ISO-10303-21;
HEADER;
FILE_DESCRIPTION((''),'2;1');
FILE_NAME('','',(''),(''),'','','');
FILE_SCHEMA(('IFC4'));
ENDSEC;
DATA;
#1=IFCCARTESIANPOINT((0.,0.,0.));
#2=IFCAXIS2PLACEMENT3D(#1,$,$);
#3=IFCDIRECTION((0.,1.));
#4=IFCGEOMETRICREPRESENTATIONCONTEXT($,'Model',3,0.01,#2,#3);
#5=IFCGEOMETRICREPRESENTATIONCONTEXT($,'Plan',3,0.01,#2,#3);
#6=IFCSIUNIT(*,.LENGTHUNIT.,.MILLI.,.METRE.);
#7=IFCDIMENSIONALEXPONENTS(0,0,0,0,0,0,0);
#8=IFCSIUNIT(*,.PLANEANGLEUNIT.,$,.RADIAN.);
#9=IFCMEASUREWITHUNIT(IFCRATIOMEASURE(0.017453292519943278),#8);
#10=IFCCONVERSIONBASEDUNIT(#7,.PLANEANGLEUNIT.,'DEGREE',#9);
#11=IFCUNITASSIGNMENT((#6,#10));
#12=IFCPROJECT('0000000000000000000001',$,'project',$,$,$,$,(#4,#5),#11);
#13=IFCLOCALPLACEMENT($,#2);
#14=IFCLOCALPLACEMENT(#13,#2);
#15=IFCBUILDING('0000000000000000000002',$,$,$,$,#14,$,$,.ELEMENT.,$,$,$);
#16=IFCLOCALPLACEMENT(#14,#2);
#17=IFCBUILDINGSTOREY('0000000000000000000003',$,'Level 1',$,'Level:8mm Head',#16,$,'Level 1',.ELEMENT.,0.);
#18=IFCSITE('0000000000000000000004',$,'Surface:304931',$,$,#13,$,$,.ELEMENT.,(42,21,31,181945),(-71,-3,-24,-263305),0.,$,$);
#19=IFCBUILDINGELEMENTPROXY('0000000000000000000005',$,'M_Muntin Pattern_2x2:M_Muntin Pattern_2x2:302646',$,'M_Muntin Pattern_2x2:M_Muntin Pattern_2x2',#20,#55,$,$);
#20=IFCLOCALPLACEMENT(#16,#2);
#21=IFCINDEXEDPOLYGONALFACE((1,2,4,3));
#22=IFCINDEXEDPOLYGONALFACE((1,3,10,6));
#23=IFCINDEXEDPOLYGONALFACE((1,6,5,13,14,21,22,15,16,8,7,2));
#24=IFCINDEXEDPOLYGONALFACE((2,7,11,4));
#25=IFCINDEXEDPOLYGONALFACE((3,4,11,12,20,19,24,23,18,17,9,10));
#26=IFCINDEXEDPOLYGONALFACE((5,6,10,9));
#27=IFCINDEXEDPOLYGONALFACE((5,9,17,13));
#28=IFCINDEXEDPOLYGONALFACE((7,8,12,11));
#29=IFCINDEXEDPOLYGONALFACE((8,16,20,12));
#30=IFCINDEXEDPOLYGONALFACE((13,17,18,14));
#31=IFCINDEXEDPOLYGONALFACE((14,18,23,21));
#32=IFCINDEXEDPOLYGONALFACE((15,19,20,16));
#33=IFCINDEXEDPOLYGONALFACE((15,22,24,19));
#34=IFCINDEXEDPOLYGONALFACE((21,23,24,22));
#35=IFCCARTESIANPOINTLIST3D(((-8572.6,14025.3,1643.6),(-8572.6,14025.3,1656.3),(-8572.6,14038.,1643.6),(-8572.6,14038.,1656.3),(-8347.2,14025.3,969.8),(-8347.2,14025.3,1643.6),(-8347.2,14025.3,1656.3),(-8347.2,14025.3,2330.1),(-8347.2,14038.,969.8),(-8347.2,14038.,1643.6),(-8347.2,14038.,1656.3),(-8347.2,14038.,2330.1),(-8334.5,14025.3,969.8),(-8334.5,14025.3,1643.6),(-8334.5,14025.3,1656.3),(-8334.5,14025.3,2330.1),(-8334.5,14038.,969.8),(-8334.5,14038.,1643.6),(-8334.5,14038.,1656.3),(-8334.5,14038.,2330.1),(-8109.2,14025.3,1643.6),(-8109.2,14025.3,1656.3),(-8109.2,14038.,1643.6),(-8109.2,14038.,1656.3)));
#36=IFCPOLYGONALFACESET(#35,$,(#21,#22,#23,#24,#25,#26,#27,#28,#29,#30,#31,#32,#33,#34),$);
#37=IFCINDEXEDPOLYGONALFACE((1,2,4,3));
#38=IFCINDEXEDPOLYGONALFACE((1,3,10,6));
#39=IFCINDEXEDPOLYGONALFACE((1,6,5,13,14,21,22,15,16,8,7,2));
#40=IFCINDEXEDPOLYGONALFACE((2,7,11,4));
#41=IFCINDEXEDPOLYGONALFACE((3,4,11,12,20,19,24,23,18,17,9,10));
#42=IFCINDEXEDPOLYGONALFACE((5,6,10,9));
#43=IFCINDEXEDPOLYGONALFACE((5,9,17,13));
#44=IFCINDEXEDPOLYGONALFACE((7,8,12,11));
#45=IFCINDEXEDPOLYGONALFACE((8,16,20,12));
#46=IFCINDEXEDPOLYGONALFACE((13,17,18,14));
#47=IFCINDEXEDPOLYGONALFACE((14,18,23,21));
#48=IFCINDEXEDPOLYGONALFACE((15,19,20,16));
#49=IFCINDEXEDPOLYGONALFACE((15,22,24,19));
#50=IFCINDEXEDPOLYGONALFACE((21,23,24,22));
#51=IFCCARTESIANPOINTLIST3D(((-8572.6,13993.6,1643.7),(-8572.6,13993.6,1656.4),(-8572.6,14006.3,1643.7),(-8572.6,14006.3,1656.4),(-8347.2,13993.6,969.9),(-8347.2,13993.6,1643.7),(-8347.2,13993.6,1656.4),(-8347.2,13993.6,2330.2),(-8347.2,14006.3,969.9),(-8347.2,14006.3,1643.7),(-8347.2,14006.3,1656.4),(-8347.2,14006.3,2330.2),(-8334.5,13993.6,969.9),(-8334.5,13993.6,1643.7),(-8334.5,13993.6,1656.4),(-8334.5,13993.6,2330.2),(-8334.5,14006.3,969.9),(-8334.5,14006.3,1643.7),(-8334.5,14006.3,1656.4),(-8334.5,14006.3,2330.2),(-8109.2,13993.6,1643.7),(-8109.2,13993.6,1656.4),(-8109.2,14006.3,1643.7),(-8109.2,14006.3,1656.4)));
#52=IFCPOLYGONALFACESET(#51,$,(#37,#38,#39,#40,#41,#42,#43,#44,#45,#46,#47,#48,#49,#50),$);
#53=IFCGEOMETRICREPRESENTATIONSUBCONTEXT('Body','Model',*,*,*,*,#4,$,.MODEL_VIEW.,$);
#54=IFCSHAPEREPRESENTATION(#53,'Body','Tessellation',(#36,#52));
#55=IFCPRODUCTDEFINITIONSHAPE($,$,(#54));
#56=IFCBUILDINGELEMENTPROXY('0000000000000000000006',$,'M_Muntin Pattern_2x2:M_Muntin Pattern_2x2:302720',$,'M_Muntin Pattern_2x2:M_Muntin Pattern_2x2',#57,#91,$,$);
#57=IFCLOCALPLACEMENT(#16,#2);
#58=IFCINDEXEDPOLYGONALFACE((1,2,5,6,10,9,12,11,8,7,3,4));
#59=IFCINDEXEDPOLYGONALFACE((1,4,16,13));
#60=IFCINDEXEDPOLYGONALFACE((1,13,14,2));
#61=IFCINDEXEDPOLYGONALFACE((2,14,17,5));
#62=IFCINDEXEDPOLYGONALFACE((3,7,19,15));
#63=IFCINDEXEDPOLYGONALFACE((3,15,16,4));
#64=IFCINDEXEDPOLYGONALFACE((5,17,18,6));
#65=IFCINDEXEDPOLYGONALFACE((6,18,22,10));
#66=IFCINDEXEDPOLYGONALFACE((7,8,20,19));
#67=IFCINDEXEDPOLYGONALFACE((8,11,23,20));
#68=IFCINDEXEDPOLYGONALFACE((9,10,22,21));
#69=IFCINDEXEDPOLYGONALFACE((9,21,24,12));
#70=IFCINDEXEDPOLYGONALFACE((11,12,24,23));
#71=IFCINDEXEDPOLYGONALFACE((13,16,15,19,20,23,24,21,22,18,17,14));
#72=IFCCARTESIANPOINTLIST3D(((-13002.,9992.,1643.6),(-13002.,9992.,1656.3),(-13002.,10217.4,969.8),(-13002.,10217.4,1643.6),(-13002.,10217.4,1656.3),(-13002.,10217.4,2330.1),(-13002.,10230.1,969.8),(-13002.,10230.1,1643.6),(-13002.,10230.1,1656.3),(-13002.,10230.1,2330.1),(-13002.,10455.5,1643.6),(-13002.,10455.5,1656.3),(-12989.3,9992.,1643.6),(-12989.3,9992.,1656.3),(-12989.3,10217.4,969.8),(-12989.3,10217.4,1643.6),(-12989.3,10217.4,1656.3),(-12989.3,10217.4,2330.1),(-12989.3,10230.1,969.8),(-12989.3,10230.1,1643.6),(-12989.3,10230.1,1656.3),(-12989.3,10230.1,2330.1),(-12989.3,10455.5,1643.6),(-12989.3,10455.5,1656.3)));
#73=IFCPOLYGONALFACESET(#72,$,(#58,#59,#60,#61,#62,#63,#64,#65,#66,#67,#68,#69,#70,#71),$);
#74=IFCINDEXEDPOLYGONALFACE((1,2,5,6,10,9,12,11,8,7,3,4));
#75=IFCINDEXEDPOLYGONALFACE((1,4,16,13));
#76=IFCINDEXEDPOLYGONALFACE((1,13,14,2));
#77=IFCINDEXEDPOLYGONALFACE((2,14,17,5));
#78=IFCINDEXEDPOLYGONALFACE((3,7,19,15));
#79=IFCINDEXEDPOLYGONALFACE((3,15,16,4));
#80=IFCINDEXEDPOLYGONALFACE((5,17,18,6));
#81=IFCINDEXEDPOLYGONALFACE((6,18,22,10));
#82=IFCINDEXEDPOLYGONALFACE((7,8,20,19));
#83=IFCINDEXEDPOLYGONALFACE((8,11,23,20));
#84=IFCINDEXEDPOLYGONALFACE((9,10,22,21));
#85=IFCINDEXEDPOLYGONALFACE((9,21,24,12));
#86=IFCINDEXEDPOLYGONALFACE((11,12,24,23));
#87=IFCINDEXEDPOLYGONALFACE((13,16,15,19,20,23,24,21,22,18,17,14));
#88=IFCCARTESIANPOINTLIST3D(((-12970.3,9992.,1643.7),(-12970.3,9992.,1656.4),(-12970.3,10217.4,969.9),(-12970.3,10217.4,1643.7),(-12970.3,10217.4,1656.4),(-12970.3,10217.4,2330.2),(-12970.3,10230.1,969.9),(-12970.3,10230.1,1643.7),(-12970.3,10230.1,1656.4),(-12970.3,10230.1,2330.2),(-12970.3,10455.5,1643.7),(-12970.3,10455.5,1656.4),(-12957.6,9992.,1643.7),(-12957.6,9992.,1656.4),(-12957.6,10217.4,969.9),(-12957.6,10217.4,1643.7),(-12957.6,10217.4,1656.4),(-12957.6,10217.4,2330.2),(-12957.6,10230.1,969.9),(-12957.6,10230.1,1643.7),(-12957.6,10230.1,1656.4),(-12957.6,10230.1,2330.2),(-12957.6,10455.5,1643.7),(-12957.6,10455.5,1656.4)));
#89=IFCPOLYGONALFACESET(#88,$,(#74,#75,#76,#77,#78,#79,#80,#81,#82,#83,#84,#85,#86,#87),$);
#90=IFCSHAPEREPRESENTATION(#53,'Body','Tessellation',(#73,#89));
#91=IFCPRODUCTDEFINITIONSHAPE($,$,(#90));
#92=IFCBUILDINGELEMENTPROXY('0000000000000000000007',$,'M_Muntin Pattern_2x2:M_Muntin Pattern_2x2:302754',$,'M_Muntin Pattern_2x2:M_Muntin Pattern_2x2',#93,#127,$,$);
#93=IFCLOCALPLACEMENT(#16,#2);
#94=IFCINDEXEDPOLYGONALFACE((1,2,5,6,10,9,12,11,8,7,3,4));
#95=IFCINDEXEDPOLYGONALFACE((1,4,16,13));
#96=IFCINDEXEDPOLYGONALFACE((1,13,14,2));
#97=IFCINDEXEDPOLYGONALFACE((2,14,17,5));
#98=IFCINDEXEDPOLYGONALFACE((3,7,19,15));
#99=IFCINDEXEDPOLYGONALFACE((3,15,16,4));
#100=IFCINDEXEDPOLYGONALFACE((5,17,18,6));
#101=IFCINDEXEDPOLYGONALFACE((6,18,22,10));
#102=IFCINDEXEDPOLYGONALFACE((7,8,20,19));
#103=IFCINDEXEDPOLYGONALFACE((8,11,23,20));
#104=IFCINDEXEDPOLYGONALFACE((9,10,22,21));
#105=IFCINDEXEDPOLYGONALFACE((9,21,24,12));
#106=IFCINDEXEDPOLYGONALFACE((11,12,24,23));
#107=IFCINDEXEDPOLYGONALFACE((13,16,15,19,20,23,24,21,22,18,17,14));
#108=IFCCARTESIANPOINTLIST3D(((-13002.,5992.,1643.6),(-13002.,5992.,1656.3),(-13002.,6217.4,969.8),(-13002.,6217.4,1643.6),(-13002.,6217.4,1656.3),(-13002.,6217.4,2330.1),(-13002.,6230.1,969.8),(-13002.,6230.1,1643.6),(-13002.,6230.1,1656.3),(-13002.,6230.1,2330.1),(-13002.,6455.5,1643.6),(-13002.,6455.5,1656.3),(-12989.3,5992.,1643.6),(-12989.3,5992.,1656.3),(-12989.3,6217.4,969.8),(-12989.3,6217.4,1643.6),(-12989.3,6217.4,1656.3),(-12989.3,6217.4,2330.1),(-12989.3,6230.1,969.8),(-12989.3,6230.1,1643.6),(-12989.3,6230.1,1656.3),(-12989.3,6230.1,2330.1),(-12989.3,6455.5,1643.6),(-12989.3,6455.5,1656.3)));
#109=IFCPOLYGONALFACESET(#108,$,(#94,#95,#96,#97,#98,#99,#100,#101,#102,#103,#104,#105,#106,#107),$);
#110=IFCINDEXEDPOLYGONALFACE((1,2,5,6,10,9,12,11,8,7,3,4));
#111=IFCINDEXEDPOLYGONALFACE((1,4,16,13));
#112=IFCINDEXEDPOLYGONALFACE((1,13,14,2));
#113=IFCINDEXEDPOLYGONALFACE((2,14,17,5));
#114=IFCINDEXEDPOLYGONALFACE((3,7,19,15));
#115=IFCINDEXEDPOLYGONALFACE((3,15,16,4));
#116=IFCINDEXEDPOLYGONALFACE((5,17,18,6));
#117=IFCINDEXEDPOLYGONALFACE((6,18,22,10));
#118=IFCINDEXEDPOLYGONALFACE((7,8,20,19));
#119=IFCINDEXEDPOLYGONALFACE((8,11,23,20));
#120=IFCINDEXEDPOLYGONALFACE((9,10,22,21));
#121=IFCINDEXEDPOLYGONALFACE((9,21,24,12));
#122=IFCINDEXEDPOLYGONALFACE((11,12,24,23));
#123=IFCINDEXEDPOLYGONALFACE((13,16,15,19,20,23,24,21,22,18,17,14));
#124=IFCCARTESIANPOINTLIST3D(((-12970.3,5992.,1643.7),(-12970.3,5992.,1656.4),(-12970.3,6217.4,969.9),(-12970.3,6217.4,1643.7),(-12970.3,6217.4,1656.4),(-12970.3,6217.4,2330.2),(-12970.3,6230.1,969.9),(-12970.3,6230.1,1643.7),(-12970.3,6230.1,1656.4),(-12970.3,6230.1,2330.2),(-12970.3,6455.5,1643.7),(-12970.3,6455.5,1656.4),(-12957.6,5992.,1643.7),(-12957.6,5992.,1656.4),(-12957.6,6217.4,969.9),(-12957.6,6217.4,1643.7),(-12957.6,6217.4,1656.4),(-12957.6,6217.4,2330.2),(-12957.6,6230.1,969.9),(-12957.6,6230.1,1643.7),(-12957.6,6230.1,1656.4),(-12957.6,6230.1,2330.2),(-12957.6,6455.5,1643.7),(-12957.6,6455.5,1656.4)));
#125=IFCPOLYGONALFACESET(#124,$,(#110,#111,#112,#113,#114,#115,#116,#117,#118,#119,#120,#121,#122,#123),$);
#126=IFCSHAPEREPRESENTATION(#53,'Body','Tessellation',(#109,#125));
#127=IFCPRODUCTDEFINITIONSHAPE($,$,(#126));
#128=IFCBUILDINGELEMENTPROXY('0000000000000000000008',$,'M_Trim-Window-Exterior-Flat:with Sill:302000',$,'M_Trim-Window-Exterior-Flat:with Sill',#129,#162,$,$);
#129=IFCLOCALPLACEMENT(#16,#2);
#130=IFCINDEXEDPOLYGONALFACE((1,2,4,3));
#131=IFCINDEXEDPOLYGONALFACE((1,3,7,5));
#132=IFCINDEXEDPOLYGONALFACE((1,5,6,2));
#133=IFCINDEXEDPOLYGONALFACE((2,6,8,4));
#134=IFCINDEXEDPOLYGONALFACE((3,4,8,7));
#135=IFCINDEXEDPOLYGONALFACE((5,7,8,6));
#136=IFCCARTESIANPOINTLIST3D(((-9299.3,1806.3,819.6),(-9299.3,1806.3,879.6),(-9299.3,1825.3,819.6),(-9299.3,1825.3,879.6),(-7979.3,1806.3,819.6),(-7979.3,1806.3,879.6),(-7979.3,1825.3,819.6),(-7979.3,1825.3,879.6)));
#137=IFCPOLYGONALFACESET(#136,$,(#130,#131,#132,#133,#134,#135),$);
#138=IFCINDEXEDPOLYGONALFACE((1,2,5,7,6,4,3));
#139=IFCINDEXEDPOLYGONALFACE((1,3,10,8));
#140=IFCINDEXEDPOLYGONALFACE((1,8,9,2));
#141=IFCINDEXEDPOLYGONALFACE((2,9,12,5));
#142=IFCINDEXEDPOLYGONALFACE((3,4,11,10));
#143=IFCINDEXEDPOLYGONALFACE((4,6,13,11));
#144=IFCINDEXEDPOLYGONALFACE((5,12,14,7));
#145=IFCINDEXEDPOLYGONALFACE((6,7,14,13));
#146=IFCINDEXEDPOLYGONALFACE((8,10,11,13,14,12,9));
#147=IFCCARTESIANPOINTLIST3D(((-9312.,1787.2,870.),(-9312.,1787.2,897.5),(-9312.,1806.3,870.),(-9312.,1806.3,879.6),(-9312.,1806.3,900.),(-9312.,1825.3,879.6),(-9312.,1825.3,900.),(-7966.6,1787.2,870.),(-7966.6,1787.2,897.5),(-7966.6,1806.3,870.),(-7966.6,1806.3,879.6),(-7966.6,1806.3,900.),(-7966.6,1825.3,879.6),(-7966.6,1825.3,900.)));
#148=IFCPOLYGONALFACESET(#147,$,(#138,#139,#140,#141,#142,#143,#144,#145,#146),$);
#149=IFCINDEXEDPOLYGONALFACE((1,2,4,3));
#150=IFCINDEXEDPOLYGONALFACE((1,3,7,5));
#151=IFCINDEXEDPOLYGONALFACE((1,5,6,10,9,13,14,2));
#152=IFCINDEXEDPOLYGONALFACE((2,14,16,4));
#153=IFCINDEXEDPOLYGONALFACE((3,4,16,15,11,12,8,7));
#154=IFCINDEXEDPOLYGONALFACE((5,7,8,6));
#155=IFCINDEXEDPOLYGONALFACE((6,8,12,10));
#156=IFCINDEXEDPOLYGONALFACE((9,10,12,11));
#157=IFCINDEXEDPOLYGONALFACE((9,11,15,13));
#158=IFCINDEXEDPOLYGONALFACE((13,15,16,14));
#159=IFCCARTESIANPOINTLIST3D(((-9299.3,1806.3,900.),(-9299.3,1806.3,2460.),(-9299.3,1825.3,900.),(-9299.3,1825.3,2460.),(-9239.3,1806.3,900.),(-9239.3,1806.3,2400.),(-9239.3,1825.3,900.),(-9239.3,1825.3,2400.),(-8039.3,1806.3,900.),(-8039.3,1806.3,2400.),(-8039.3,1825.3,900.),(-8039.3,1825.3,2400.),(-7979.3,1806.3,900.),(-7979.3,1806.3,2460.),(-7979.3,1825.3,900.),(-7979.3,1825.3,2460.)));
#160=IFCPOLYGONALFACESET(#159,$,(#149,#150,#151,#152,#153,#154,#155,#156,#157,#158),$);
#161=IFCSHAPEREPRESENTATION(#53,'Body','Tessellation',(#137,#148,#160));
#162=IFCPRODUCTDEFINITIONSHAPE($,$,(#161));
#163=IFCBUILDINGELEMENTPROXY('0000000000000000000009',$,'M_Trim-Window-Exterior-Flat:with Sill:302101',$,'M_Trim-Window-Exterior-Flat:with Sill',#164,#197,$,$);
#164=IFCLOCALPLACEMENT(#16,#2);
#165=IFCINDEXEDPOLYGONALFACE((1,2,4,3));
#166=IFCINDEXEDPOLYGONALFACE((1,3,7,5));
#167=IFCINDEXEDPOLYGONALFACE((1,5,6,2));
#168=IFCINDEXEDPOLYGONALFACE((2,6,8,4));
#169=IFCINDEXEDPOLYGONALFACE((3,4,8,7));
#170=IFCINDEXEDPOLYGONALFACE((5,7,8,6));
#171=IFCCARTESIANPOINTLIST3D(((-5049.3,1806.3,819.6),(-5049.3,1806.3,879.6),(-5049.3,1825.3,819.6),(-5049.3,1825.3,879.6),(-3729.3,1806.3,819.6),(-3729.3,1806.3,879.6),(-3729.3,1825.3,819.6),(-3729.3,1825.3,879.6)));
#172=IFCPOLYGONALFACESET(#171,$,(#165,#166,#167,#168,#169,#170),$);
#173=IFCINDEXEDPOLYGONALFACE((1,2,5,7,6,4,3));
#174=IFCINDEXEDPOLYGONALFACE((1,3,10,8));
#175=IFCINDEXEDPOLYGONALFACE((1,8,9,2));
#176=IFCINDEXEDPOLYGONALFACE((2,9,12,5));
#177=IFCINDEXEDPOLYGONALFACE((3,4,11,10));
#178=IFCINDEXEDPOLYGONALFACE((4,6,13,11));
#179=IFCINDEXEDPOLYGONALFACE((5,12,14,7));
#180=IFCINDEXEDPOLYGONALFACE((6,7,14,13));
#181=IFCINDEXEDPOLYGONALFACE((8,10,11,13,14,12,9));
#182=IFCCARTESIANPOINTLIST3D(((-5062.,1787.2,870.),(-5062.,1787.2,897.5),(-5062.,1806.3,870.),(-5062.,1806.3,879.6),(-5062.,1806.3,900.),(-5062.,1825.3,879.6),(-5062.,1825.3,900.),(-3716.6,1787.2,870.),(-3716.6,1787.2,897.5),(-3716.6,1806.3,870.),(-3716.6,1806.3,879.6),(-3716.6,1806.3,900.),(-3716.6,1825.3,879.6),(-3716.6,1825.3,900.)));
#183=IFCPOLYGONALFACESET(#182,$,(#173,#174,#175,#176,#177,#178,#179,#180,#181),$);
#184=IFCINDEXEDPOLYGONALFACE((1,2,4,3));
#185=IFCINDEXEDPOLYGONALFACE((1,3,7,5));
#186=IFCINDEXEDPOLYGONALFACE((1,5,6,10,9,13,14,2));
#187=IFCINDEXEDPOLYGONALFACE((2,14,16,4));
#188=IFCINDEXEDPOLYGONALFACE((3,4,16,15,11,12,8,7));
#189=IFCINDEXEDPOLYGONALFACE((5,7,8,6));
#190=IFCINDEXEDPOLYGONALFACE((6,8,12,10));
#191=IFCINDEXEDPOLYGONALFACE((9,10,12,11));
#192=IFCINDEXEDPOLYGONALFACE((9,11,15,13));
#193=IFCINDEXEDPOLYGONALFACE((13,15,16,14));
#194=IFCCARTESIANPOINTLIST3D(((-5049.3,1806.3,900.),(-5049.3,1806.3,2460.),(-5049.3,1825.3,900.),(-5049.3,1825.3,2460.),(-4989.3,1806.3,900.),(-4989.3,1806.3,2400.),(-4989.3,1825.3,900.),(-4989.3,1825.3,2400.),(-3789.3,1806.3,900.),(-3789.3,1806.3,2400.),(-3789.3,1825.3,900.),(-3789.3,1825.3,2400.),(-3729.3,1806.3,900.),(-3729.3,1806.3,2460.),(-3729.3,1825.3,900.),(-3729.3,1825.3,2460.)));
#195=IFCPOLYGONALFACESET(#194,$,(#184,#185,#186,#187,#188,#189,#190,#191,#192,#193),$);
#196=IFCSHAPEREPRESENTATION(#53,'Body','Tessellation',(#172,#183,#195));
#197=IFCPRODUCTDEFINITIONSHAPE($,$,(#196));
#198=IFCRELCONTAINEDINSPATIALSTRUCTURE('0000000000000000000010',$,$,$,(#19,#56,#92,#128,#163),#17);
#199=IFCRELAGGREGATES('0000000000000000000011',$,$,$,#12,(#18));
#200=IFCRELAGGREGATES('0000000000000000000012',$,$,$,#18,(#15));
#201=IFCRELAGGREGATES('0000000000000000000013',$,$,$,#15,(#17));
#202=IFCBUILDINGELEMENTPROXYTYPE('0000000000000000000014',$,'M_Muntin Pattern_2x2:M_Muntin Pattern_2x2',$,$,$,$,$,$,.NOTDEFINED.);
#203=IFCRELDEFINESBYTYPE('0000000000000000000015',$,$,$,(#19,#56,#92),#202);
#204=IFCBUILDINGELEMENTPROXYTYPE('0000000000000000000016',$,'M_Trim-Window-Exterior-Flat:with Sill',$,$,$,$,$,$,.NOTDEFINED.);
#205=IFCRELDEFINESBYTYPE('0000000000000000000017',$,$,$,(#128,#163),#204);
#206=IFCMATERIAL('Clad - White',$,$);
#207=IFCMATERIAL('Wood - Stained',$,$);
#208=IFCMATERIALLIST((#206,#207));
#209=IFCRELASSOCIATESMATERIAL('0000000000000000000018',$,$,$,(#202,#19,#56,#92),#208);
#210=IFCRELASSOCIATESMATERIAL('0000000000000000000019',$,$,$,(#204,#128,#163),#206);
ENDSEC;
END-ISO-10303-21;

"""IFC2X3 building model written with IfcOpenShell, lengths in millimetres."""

from ifc_helpers import new_model, entity, si_unit, converted_unit, direction, frame, frame_2d, origin, place, context, subcontext, project, spatial, polyline, rectangle, outline, extrude, source, transform, mapped, material, material_list, type_object, type_shapes, element, save


model = new_model("IFC2X3")

# Units and contexts
model_context = context("Model", 3, precision=0.01, world=origin(), true_north=direction((0.0, 1.0)))
plan_context = context("Plan", 3, precision=0.01, world=origin(), true_north=direction((0.0, 1.0)))
body_context = subcontext(model_context, "Body", "Model", "MODEL_VIEW")
ifc_project = project(units=[si_unit("LENGTHUNIT", "METRE", prefix="MILLI"), converted_unit("PLANEANGLEUNIT", "DEGREE", entity("IfcRatioMeasure", 0.017453292519943278), si_unit("PLANEANGLEUNIT", "RADIAN"), dimensions=[0, 0, 0, 0, 0, 0, 0])], contexts=[model_context, plan_context])

# Site, building, storey
site_placement = place(None, origin())
site = spatial("IfcSite", under=ifc_project, at=site_placement, Name="Surface:304931", CompositionType="ELEMENT", RefLatitude=(42, 21, 31, 181945), RefLongitude=(-71, -3, -24, -263305), RefElevation=0.0)
building_placement = place(site_placement, origin())
building = spatial("IfcBuilding", under=site, at=building_placement, CompositionType="ELEMENT")
storey_placement = place(building_placement, origin())
storey = spatial("IfcBuildingStorey", under=building, at=storey_placement, Name="Level 1", ObjectType="Level:8mm Head", LongName="Level 1", CompositionType="ELEMENT", Elevation=0.0)

# Building element proxies
ifc_material_1 = material(Name="Clad - White")
ifc_material_2 = material(Name="Wood - Stained")
ifc_material_list = material_list([ifc_material_1, ifc_material_2])
building_element_proxy_type_1 = type_object("IfcBuildingElementProxyType", Name="M_Muntin Pattern_2x2:M_Muntin Pattern_2x2", PredefinedType="NOTDEFINED", material=ifc_material_list)
shared_shape_1 = source(origin(), body_context, "Body", "SweptSolid", [
    extrude(outline(polyline([(6.4, -6.4), (680.1, -6.4), (680.1, 6.3), (6.4, 6.3), (6.4, 231.7), (-6.3, 231.7), (-6.3, 6.3), (-680.2, 6.3), (-680.2, -6.4), (-6.3, -6.4), (-6.3, -231.7), (6.4, -231.7), (6.4, -6.4)])), frame((0.0, -22.2, 680.1), z_axis=(0.0, 1.0, 0.0), x_axis=(0.0, 0.0, 1.0)), (0.0, 0.0, 1.0), 12.7),
    extrude(outline(polyline([(6.4, -6.4), (680.2, -6.4), (680.2, 6.3), (6.4, 6.3), (6.4, 231.7), (-6.3, 231.7), (-6.3, 6.3), (-680.2, 6.3), (-680.2, -6.4), (-6.3, -6.4), (-6.3, -231.7), (6.4, -231.7), (6.4, -6.4)])), frame((0.0, 9.5, 680.2), z_axis=(0.0, 1.0, 0.0), x_axis=(0.0, 0.0, 1.0)), (0.0, 0.0, 1.0), 12.7),
])
type_shapes(building_element_proxy_type_1, [shared_shape_1])
for number, where, z_axis, x_axis, name in (
    (1, (-8340.9, 14015.8, 969.9), (0.0, 0.0, 1.0), (-1.0, 0.0, 0.0), "M_Muntin Pattern_2x2:M_Muntin Pattern_2x2:302646"),
    (2, (-12979.8, 10223.7, 969.9), (0.0, 0.0, 1.0), (0.0, -1.0, 0.0), "M_Muntin Pattern_2x2:M_Muntin Pattern_2x2:302720"),
    (3, (-12979.8, 6223.7, 969.9), (0.0, 0.0, 1.0), (0.0, -1.0, 0.0), "M_Muntin Pattern_2x2:M_Muntin Pattern_2x2:302754"),
):
    element("IfcBuildingElementProxy", number, at=place(storey_placement, frame(where, z_axis=z_axis, x_axis=x_axis)), inside=storey, type_object=building_element_proxy_type_1, material=ifc_material_list, Name=name, ObjectType="M_Muntin Pattern_2x2:M_Muntin Pattern_2x2", context=body_context, shape_type="MappedRepresentation", body=[
        mapped(shared_shape_1, transform((0.0, 0.0, 0.0), scale=1.0)),
    ])
building_element_proxy_type_2 = type_object("IfcBuildingElementProxyType", Name="M_Trim-Window-Exterior-Flat:with Sill", PredefinedType="NOTDEFINED", material=ifc_material_1)
shared_shape_2 = source(origin(), body_context, "Body", "SweptSolid", [
    extrude(rectangle(XDim=1320.0, YDim=60.0, at=frame_2d((0.0, 0.0), x_axis=(1.0, 0.0))), frame((0.0, -1550.4, 0.0), z_axis=(0.0, 0.0, 1.0), x_axis=(-1.0, 0.0, 0.0)), (0.0, 0.0, 1.0), 19.0),
    extrude(outline(polyline([(-19.0, -15.2), (0.0, -15.2), (0.0, -5.7), (19.0, -5.7), (19.0, 14.8), (0.0, 14.8), (-19.0, 12.3), (-19.0, -15.2)])), frame((-672.7, -1514.8, 19.0), z_axis=(1.0, 0.0, 0.0), x_axis=(0.0, 0.0, -1.0)), (0.0, 0.0, 1.0), 1345.4),
    extrude(outline(polyline([(-795.0, -660.0), (765.0, -660.0), (765.0, -600.0), (-735.0, -600.0), (-735.0, 600.0), (765.0, 600.0), (765.0, 660.0), (-795.0, 660.0), (-795.0, -660.0)])), frame((0.0, -735.0, 0.0), z_axis=(0.0, 0.0, 1.0), x_axis=(0.0, -1.0, 0.0)), (0.0, 0.0, 1.0), 19.0),
])
type_shapes(building_element_proxy_type_2, [shared_shape_2])
for number, where, z_axis, x_axis, name in (
    (4, (-8639.3, 1825.3, 2400.0), (0.0, -1.0, 0.0), (1.0, 0.0, 0.0), "M_Trim-Window-Exterior-Flat:with Sill:302000"),
    (5, (-4389.3, 1825.3, 2400.0), (0.0, -1.0, 0.0), (1.0, 0.0, 0.0), "M_Trim-Window-Exterior-Flat:with Sill:302101"),
):
    element("IfcBuildingElementProxy", number, at=place(storey_placement, frame(where, z_axis=z_axis, x_axis=x_axis)), inside=storey, type_object=building_element_proxy_type_2, material=ifc_material_1, Name=name, ObjectType="M_Trim-Window-Exterior-Flat:with Sill", context=body_context, shape_type="MappedRepresentation", body=[
        mapped(shared_shape_2, transform((0.0, 0.0, 0.0), scale=1.0)),
    ])

save(model, "model.ifc")
